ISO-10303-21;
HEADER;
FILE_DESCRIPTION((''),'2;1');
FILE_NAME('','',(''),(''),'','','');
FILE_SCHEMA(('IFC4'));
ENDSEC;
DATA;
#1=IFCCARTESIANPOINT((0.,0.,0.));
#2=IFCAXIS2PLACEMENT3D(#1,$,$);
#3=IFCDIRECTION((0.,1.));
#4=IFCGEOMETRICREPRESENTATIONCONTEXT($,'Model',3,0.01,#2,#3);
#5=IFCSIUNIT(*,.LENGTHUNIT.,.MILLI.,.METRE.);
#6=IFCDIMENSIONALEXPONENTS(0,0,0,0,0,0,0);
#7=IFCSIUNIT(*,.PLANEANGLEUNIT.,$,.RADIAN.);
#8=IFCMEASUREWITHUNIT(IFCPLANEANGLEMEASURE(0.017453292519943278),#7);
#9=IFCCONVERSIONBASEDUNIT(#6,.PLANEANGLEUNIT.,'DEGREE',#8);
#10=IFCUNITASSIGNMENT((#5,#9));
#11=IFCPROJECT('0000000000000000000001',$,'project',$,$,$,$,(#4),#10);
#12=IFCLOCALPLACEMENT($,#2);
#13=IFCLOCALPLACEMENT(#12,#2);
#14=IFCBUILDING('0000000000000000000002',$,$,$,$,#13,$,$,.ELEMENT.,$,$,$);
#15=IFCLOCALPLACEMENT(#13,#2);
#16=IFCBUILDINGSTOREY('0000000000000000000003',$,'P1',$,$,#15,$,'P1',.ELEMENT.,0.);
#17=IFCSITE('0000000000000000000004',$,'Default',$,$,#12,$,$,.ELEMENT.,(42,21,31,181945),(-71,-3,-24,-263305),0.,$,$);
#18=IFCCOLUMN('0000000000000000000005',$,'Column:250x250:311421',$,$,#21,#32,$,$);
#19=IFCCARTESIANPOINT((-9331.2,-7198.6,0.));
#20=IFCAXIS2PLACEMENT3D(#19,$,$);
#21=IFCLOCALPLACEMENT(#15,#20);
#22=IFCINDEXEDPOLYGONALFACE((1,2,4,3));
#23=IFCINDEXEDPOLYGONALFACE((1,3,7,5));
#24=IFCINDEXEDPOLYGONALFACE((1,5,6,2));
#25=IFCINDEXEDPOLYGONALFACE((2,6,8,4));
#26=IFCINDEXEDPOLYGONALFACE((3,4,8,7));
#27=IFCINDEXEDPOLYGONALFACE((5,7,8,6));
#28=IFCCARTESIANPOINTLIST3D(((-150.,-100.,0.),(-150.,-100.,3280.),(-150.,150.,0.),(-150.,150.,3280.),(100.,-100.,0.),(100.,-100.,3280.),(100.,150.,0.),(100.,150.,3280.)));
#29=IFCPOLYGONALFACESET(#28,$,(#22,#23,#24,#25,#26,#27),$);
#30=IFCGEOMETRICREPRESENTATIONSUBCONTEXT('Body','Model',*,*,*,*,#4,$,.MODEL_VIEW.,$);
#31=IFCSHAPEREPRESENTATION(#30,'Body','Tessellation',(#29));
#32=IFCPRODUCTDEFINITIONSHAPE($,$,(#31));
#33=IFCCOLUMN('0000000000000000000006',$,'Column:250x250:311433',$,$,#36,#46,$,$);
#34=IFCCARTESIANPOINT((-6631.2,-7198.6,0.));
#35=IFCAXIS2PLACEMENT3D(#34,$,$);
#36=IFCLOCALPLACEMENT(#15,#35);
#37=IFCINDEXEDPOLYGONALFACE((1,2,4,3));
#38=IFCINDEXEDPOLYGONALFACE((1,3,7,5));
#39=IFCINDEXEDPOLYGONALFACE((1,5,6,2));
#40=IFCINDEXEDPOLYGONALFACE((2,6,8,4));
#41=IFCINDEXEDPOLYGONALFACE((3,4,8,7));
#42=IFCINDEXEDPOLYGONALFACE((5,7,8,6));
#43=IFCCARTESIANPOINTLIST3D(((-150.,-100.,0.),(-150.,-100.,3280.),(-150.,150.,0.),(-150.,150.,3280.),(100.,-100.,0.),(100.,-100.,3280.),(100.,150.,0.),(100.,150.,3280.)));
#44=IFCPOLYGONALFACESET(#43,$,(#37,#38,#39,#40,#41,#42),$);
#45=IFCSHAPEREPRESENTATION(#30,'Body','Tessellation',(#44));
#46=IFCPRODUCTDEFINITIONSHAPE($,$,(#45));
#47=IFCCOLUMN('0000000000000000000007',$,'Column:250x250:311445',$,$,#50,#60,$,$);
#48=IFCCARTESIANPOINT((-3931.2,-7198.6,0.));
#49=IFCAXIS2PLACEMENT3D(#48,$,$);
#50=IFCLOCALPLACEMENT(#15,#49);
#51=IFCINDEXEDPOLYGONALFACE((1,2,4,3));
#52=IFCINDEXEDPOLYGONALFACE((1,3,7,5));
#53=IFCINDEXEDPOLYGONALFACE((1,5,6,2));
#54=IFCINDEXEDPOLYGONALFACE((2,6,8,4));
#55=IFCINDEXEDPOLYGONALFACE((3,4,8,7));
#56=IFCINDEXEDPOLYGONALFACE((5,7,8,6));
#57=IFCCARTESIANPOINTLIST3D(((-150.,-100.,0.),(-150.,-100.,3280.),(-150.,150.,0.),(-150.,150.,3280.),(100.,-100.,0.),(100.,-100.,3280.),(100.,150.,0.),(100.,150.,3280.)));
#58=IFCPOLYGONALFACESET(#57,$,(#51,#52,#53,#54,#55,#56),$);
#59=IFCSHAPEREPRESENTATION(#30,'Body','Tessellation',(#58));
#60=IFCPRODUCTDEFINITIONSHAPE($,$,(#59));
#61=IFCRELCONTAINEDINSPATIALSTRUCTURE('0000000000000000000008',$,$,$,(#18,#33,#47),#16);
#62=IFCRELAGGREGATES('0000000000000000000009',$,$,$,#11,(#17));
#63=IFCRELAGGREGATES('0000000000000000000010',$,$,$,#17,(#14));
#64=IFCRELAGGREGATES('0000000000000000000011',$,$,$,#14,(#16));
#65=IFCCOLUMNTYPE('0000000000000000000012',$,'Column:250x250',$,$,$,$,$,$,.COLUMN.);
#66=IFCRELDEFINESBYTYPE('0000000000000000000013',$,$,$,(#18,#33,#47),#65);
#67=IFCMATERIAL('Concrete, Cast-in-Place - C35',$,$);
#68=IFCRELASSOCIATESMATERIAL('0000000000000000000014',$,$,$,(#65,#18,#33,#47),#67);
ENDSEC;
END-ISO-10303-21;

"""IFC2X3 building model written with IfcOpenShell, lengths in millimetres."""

from ifc_helpers import new_model, entity, si_unit, converted_unit, direction, frame, origin, origin_2d_with_axis, place, context, subcontext, project, spatial, rectangle, extrude, source, transform, mapped, material, type_object, type_shapes, element, save


model = new_model("IFC2X3")

# Units and contexts
model_context = context("Model", 3, precision=0.01, world=origin(), true_north=direction((0.0, 1.0)))
body_context = subcontext(model_context, "Body", "Model", "MODEL_VIEW")
ifc_project = project(units=[si_unit("LENGTHUNIT", "METRE", prefix="MILLI"), converted_unit("PLANEANGLEUNIT", "DEGREE", entity("IfcPlaneAngleMeasure", 0.017453292519943278), si_unit("PLANEANGLEUNIT", "RADIAN"), dimensions=[0, 0, 0, 0, 0, 0, 0])], contexts=[model_context])

# Site, building, storey
site_placement = place(None, origin())
site = spatial("IfcSite", under=ifc_project, at=site_placement, Name="Default", CompositionType="ELEMENT", RefLatitude=(42, 21, 31, 181945), RefLongitude=(-71, -3, -24, -263305), RefElevation=0.0)
building_placement = place(site_placement, origin())
building = spatial("IfcBuilding", under=site, at=building_placement, CompositionType="ELEMENT")
storey_placement = place(building_placement, origin())
storey = spatial("IfcBuildingStorey", under=building, at=storey_placement, Name="P1", LongName="P1", CompositionType="ELEMENT", Elevation=0.0)

# Columns
ifc_material = material(Name="Concrete, Cast-in-Place - C35")
column_type_1 = type_object("IfcColumnType", Name="Column:250x250", PredefinedType="COLUMN", material=ifc_material)
shared_shape_1 = source(origin(), body_context, "Body", "SweptSolid", [
    extrude(rectangle(XDim=250.0, YDim=250.0, at=origin_2d_with_axis()), frame((-25.0, 25.0, 0.0), z_axis=(0.0, 0.0, 1.0), x_axis=(-1.0, 0.0, 0.0)), (0.0, 0.0, 1.0), 3280.0),
])
type_shapes(column_type_1, [shared_shape_1])
for number, where, name in (
    (1, (-9331.2, -7198.6, 0.0), "Column:250x250:311421"),
    (2, (-6631.2, -7198.6, 0.0), "Column:250x250:311433"),
    (3, (-3931.2, -7198.6, 0.0), "Column:250x250:311445"),
):
    element("IfcColumn", number, at=place(storey_placement, frame(where)), inside=storey, type_object=column_type_1, material=ifc_material, Name=name, context=body_context, shape_type="MappedRepresentation", body=[
        mapped(shared_shape_1, transform((0.0, 0.0, 0.0), scale=1.0)),
    ])

save(model, "model.ifc")
